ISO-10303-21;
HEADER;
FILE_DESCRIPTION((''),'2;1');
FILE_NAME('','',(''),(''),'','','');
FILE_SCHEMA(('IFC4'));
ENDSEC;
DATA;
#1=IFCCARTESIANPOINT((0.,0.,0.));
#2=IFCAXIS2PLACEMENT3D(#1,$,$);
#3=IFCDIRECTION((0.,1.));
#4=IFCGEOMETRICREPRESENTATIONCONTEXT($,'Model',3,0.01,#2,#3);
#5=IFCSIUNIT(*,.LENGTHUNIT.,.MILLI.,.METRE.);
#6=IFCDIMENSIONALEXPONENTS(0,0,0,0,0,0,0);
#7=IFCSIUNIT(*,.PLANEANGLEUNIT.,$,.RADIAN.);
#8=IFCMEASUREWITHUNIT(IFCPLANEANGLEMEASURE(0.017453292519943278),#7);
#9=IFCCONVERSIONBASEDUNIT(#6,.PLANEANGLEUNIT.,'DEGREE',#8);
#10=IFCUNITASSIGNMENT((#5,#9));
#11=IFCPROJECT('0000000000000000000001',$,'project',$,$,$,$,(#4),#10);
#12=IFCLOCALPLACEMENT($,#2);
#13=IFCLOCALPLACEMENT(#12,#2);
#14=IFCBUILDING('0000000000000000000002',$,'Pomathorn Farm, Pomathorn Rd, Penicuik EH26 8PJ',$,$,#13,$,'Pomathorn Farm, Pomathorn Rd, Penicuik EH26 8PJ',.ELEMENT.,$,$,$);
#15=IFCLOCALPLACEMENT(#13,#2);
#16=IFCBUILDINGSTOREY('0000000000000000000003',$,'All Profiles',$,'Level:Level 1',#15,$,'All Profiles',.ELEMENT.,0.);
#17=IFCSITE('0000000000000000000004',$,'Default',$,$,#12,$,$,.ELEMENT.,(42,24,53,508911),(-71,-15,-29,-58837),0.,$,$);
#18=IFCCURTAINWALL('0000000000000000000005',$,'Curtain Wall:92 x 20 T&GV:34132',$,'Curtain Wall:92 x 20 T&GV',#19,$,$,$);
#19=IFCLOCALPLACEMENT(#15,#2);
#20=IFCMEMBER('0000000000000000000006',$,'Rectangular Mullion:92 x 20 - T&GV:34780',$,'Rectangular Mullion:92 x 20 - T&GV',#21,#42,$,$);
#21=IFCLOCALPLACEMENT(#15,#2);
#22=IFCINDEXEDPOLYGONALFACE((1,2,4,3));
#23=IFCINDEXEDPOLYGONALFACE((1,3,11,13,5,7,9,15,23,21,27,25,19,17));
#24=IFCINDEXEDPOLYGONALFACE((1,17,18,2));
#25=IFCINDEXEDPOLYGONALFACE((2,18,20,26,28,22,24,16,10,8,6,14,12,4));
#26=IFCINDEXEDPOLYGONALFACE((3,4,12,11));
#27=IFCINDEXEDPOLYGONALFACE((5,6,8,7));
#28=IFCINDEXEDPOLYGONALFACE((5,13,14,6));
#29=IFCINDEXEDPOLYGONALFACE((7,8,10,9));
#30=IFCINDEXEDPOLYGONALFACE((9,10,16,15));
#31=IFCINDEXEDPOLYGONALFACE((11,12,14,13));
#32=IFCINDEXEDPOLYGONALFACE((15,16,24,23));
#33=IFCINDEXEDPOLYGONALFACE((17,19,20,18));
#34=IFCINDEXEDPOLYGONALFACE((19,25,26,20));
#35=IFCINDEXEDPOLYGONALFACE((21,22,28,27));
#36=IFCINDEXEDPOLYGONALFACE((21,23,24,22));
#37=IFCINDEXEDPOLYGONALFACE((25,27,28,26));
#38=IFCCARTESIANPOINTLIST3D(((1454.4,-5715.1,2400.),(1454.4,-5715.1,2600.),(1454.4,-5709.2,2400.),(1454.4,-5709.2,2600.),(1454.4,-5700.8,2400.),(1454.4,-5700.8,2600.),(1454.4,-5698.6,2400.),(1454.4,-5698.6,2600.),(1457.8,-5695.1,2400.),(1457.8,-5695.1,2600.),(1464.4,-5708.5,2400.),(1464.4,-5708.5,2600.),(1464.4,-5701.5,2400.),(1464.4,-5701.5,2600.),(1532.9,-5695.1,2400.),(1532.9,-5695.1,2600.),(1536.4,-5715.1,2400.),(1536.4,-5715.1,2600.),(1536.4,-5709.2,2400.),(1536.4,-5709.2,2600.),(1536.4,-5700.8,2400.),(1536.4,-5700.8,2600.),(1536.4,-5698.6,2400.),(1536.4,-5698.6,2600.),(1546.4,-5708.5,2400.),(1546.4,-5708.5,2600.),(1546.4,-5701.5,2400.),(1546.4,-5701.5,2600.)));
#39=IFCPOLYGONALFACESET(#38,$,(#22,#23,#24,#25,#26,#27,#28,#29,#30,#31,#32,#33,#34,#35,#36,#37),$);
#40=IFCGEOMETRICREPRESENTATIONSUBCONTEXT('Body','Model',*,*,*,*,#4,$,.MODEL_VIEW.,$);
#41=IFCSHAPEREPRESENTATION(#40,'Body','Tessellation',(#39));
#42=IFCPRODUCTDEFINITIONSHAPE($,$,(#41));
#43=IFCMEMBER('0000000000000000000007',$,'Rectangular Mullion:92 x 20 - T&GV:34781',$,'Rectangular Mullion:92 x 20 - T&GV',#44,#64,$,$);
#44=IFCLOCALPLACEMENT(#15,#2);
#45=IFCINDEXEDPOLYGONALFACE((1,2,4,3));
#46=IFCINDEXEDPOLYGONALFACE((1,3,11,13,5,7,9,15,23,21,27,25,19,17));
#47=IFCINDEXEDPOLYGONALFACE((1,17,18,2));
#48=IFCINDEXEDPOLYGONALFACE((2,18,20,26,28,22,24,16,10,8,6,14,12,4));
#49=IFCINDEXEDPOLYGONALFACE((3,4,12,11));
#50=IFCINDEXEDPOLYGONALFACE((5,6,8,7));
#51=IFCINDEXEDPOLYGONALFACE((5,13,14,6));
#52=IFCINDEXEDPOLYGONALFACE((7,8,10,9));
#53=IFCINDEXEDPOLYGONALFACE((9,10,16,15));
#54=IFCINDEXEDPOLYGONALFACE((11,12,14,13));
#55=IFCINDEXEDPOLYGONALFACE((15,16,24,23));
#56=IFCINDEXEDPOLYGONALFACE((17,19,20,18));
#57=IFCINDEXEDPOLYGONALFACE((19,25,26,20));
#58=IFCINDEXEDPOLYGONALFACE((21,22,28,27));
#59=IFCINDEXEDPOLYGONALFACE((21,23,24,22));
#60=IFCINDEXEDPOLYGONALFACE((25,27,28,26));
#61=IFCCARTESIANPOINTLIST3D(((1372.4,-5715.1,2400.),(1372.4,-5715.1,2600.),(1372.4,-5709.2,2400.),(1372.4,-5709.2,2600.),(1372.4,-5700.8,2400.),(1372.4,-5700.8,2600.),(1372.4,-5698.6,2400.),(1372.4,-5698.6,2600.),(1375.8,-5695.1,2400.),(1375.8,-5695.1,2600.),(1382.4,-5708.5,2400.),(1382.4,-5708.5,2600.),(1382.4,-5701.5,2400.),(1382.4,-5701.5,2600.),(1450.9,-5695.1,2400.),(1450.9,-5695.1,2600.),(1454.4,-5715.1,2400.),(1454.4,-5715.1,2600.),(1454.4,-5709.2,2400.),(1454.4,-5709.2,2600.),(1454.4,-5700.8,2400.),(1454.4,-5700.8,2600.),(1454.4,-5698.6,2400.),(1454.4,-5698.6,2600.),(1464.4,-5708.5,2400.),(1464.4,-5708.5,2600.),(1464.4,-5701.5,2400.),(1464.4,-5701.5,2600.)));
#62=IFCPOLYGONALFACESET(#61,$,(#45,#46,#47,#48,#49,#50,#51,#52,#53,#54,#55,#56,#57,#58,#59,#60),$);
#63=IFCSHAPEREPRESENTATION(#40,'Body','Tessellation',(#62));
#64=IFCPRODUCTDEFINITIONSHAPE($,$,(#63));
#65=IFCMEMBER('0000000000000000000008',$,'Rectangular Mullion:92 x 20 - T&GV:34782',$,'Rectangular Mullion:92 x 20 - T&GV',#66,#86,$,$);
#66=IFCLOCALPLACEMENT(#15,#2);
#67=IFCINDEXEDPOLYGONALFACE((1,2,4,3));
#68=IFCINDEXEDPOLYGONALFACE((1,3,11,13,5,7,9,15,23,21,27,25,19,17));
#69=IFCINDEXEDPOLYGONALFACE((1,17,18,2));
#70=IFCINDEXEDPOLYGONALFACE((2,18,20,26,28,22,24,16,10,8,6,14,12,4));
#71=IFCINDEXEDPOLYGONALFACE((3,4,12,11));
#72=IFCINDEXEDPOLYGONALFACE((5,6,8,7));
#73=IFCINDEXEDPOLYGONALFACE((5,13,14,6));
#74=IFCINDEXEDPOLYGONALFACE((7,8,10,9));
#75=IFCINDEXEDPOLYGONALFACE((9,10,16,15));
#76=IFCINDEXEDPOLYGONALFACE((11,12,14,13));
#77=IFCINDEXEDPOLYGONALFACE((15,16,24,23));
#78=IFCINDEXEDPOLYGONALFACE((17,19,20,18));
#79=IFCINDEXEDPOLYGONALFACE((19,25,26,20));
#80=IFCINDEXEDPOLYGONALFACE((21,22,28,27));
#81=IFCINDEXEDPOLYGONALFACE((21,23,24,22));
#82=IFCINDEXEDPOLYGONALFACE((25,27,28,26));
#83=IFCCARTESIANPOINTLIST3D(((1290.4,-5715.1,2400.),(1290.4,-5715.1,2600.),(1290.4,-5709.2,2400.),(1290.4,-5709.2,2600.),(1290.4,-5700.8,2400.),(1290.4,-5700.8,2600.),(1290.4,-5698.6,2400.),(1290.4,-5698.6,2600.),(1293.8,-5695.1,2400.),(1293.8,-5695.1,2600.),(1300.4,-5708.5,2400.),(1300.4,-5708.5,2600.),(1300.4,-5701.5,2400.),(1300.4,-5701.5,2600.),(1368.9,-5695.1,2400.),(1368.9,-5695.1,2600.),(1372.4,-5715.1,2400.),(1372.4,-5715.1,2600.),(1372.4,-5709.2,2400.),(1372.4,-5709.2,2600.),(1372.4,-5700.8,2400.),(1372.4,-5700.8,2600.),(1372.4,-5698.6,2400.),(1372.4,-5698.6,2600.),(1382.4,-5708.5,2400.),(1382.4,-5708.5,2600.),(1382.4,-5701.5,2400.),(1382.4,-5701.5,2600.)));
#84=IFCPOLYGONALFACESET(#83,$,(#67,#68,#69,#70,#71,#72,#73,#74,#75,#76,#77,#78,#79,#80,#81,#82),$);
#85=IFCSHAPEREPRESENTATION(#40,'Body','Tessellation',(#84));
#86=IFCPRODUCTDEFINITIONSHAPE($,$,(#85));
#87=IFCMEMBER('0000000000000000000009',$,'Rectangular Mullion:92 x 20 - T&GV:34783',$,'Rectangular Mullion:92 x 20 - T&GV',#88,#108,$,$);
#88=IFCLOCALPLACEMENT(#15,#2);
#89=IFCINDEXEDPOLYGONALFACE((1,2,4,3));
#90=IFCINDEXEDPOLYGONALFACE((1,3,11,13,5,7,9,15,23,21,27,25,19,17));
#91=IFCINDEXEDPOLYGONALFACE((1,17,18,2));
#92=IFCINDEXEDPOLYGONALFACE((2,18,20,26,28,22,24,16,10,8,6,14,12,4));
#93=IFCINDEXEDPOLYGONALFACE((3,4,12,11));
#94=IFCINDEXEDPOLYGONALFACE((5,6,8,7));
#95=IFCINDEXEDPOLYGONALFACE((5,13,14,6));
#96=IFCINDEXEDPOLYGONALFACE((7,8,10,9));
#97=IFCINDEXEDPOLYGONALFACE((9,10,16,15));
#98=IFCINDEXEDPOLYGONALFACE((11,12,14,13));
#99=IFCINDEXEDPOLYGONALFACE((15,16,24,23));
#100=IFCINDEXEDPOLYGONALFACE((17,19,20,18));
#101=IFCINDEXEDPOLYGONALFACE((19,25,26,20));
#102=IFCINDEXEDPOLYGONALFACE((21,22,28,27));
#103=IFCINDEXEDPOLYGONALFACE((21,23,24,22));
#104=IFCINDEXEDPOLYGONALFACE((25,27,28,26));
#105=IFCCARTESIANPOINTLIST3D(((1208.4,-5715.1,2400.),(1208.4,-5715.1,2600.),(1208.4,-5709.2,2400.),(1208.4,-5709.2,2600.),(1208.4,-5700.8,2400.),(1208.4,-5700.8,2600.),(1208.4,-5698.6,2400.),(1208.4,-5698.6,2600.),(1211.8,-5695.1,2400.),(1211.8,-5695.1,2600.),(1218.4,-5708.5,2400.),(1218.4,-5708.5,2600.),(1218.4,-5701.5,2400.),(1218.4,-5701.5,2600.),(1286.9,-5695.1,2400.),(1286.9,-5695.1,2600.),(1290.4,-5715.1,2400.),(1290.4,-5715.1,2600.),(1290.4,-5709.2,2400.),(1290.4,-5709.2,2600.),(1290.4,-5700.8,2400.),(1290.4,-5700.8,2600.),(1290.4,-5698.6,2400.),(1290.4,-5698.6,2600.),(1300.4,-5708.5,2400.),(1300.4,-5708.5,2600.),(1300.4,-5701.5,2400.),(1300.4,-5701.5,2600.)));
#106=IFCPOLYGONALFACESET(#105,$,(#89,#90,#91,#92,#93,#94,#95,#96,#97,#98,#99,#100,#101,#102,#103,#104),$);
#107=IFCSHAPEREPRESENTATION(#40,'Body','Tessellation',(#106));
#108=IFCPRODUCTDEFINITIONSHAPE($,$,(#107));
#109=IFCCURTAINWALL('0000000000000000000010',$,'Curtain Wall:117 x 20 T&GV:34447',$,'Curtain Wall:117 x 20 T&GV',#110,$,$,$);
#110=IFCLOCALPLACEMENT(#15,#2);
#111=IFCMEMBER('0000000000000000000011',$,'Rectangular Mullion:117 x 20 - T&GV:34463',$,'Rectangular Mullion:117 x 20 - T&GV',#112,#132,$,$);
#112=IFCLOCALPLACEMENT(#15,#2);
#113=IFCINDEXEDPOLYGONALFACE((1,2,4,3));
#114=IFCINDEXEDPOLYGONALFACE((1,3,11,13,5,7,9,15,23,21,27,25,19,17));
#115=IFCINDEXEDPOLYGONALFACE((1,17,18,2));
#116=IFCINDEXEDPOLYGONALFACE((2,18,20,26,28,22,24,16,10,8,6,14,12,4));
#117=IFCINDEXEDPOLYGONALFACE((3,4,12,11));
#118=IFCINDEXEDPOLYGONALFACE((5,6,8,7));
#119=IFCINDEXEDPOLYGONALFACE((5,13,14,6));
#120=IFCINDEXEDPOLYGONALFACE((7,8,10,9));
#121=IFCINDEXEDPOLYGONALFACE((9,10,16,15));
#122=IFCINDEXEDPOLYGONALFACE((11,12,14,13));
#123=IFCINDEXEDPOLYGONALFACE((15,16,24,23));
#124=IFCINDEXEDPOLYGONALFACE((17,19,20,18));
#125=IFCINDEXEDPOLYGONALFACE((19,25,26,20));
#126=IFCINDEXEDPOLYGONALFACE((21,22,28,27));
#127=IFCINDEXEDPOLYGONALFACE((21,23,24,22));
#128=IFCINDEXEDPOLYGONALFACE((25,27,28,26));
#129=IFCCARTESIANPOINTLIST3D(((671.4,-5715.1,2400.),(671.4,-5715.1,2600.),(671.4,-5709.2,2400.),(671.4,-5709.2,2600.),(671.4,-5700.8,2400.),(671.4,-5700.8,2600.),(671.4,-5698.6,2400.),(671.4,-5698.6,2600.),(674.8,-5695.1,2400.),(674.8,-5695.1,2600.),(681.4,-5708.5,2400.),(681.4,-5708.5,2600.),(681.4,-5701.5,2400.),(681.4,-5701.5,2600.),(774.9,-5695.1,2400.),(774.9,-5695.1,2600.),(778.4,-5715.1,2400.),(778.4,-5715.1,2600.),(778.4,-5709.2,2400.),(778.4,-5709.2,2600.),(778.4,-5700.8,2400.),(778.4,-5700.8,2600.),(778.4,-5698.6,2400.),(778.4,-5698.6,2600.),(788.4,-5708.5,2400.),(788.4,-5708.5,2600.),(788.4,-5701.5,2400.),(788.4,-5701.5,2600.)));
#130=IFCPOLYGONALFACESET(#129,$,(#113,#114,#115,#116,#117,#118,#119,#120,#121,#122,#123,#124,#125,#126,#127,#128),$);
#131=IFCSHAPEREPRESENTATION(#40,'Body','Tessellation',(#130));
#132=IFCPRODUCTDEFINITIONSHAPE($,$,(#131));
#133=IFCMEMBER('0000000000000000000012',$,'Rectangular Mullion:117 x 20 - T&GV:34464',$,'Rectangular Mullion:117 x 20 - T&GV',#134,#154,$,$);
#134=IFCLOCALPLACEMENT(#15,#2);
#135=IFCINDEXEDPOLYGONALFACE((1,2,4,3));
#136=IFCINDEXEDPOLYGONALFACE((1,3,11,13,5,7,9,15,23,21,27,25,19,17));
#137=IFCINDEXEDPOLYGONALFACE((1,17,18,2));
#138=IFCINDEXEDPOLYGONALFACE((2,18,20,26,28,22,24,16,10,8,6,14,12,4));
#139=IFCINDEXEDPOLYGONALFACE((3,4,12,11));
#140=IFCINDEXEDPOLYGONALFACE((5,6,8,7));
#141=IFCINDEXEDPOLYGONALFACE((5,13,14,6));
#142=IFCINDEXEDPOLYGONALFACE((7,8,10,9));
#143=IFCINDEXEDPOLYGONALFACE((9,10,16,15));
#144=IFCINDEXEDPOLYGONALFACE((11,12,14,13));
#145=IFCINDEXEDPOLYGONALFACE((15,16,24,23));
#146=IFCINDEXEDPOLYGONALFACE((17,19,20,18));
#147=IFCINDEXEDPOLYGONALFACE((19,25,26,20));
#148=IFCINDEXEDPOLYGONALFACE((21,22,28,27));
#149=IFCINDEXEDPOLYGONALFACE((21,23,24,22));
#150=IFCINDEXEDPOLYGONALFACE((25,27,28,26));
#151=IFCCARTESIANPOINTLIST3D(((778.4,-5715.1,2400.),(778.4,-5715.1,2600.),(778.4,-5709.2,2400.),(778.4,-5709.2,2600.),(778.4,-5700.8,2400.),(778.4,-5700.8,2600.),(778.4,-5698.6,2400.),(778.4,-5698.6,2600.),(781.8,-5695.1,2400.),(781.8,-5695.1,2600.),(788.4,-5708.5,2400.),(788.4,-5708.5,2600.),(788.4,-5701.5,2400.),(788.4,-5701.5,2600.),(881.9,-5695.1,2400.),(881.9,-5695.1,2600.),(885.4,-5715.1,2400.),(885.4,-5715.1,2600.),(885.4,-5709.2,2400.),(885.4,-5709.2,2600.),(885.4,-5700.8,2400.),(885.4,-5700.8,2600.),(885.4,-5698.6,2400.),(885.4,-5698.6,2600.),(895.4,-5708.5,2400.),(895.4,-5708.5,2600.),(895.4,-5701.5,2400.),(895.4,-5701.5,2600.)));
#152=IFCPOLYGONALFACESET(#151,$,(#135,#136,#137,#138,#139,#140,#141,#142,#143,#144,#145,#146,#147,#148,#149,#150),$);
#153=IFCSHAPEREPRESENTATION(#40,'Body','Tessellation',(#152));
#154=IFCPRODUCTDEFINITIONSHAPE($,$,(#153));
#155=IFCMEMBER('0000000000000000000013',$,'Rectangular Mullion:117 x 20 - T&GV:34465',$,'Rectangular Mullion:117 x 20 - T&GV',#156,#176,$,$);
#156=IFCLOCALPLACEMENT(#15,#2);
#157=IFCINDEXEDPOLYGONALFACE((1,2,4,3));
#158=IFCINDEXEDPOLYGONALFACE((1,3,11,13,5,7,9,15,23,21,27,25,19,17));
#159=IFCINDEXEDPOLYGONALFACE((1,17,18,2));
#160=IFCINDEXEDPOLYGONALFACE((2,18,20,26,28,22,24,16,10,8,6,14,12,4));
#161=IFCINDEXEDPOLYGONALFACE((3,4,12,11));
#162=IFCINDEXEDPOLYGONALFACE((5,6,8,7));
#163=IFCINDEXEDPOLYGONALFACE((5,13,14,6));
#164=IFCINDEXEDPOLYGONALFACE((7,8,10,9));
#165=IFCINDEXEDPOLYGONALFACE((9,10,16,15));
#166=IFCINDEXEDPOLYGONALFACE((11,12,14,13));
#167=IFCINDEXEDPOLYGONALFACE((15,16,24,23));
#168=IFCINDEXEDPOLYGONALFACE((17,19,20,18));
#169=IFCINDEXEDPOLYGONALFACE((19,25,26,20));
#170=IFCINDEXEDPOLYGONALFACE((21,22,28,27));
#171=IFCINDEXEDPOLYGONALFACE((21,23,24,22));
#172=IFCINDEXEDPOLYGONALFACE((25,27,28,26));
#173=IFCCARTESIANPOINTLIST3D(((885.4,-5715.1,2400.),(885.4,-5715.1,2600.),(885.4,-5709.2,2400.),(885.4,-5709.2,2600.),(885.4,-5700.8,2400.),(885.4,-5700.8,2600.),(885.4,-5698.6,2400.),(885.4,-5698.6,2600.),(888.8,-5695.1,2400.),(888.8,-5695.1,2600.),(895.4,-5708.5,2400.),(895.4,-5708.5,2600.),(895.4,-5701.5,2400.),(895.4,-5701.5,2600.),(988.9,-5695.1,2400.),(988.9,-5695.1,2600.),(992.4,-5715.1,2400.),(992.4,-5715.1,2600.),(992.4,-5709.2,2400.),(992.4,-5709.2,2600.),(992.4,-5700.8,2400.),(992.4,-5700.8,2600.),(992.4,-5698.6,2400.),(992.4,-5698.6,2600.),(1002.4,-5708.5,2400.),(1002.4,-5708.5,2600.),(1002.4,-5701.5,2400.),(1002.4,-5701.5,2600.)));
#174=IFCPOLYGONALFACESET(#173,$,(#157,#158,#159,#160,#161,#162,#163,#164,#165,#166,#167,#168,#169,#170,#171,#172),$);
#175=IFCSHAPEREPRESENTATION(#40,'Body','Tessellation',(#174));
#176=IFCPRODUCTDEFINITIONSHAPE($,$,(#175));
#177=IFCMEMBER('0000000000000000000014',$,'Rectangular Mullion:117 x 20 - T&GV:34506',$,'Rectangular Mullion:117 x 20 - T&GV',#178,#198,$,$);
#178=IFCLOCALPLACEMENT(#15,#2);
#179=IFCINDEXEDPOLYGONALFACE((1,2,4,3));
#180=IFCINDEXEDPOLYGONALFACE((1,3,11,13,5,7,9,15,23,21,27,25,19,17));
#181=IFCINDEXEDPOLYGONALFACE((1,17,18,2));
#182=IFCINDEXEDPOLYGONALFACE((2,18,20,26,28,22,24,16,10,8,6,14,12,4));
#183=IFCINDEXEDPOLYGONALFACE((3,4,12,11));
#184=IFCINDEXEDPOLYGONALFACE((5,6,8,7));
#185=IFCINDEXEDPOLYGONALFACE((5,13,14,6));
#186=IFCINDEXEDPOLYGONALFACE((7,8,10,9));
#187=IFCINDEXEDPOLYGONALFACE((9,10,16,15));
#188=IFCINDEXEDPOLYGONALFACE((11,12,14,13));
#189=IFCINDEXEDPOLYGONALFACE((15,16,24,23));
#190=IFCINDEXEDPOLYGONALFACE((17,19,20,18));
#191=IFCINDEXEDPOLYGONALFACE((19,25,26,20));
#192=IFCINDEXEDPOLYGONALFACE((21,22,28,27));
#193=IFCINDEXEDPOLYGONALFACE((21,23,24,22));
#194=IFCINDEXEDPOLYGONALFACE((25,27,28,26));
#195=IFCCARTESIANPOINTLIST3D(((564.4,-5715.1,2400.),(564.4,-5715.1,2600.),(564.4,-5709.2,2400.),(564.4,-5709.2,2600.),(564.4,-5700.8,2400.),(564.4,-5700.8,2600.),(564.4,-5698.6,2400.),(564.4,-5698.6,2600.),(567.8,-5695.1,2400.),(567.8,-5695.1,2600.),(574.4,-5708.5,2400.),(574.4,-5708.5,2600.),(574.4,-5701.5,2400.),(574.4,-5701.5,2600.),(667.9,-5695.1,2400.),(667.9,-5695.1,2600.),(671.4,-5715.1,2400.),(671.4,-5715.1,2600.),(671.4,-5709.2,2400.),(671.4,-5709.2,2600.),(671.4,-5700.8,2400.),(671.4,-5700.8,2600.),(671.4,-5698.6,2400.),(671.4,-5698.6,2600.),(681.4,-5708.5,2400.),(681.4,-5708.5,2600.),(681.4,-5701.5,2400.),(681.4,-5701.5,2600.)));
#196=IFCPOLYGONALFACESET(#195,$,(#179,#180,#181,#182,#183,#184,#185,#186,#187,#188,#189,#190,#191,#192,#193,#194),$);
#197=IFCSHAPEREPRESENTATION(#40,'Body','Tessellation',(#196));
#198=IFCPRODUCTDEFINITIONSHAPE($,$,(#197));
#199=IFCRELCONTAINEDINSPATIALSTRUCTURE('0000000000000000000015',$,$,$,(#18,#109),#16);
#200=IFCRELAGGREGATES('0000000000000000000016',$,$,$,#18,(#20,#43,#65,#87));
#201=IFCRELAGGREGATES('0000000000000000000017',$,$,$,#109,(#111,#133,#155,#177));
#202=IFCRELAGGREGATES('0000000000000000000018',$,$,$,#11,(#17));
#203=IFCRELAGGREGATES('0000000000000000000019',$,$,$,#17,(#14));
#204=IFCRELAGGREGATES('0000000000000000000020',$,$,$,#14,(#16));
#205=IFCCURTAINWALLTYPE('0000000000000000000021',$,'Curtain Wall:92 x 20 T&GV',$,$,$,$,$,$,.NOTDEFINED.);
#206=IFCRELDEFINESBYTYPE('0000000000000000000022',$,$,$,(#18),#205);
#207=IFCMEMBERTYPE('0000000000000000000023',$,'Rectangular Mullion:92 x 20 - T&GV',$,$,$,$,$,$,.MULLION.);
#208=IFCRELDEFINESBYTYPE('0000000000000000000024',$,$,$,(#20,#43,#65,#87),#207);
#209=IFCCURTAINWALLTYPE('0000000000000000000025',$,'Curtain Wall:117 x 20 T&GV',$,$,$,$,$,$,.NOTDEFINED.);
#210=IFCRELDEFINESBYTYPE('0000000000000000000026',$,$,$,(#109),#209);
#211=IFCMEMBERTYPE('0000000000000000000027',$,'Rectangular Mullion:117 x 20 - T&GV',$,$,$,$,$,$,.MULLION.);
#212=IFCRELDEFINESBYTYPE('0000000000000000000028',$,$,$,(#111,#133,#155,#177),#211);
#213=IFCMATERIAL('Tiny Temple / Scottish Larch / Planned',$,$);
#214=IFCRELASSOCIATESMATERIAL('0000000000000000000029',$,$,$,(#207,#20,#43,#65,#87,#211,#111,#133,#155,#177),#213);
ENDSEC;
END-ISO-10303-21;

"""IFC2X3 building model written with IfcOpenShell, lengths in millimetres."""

from ifc_helpers import new_model, entity, si_unit, converted_unit, direction, frame, origin, place, context, subcontext, project, spatial, polyline, outline, extrude, source, transform, mapped, material, type_object, type_shapes, element, aggregate, save


model = new_model("IFC2X3")

# Units and contexts
model_context = context("Model", 3, precision=0.01, world=origin(), true_north=direction((0.0, 1.0)))
body_context = subcontext(model_context, "Body", "Model", "MODEL_VIEW")
ifc_project = project(units=[si_unit("LENGTHUNIT", "METRE", prefix="MILLI"), converted_unit("PLANEANGLEUNIT", "DEGREE", entity("IfcPlaneAngleMeasure", 0.017453292519943278), si_unit("PLANEANGLEUNIT", "RADIAN"), dimensions=[0, 0, 0, 0, 0, 0, 0])], contexts=[model_context])

# Site, building, storey
site_placement = place(None, origin())
site = spatial("IfcSite", under=ifc_project, at=site_placement, Name="Default", CompositionType="ELEMENT", RefLatitude=(42, 24, 53, 508911), RefLongitude=(-71, -15, -29, -58837), RefElevation=0.0)
building_placement = place(site_placement, origin())
building = spatial("IfcBuilding", under=site, at=building_placement, Name="Pomathorn Farm, Pomathorn Rd, Penicuik EH26 8PJ", LongName="Pomathorn Farm, Pomathorn Rd, Penicuik EH26 8PJ", CompositionType="ELEMENT")
storey_placement = place(building_placement, origin())
storey = spatial("IfcBuildingStorey", under=building, at=storey_placement, Name="All Profiles", ObjectType="Level:Level 1", LongName="All Profiles", CompositionType="ELEMENT", Elevation=0.0)

# Shared definitions
ifc_material = material(Name="Tiny Temple / Scottish Larch / Planned")

# Curtain walls, members
curtain_wall_type_1 = type_object("IfcCurtainWallType", Name="Curtain Wall:92 x 20 T&GV", PredefinedType="NOTDEFINED")
curtain_wall_1_placement = place(storey_placement, origin())
curtain_wall_1 = element("IfcCurtainWall", 1, at=curtain_wall_1_placement, inside=storey, type_object=curtain_wall_type_1, Name="Curtain Wall:92 x 20 T&GV:34132", ObjectType="Curtain Wall:92 x 20 T&GV")
member_type_1 = type_object("IfcMemberType", Name="Rectangular Mullion:92 x 20 - T&GV", PredefinedType="MULLION", material=ifc_material)
shared_shape_1 = source(origin(), body_context, "Body", "SweptSolid", [
    extrude(outline(polyline([(-38.1, -11.0), (43.9, -11.0), (43.9, -5.1), (33.9, -4.4), (33.9, 2.6), (43.9, 3.3), (43.9, 5.5), (40.4, 9.0), (-34.7, 9.0), (-38.1, 5.5), (-38.1, 3.3), (-48.1, 2.6), (-48.1, -4.4), (-38.1, -5.1), (-38.1, -11.0)])), frame((-48.1, -11.0, -200.0), z_axis=(0.0, 0.0, 1.0), x_axis=(-1.0, 0.0, 0.0)), (0.0, 0.0, 1.0), 200.0),
])
type_shapes(member_type_1, [shared_shape_1])
member_1_placement = place(curtain_wall_1_placement, frame((1546.4, -5715.1, 2400.0), z_axis=(0.0, 0.0, -1.0), x_axis=(1.0, 0.0, 0.0)))
member_1 = element("IfcMember", 2, at=member_1_placement, type_object=member_type_1, material=ifc_material, Name="Rectangular Mullion:92 x 20 - T&GV:34780", ObjectType="Rectangular Mullion:92 x 20 - T&GV", context=body_context, shape_type="MappedRepresentation", body=[
    mapped(shared_shape_1, transform((0.0, 0.0, 0.0), scale=1.0)),
])
member_2_placement = place(curtain_wall_1_placement, frame((1464.4, -5715.1, 2400.0), z_axis=(0.0, 0.0, -1.0), x_axis=(1.0, 0.0, 0.0)))
member_2 = element("IfcMember", 3, at=member_2_placement, type_object=member_type_1, material=ifc_material, Name="Rectangular Mullion:92 x 20 - T&GV:34781", ObjectType="Rectangular Mullion:92 x 20 - T&GV", context=body_context, shape_type="MappedRepresentation", body=[
    mapped(shared_shape_1, transform((0.0, 0.0, 0.0), scale=1.0)),
])
member_3_placement = place(curtain_wall_1_placement, frame((1382.4, -5715.1, 2400.0), z_axis=(0.0, 0.0, -1.0), x_axis=(1.0, 0.0, 0.0)))
member_3 = element("IfcMember", 4, at=member_3_placement, type_object=member_type_1, material=ifc_material, Name="Rectangular Mullion:92 x 20 - T&GV:34782", ObjectType="Rectangular Mullion:92 x 20 - T&GV", context=body_context, shape_type="MappedRepresentation", body=[
    mapped(shared_shape_1, transform((0.0, 0.0, 0.0), scale=1.0)),
])
member_4_placement = place(curtain_wall_1_placement, frame((1300.4, -5715.1, 2400.0), z_axis=(0.0, 0.0, -1.0), x_axis=(1.0, 0.0, 0.0)))
member_4 = element("IfcMember", 5, at=member_4_placement, type_object=member_type_1, material=ifc_material, Name="Rectangular Mullion:92 x 20 - T&GV:34783", ObjectType="Rectangular Mullion:92 x 20 - T&GV", context=body_context, shape_type="MappedRepresentation", body=[
    mapped(shared_shape_1, transform((0.0, 0.0, 0.0), scale=1.0)),
])
aggregate(curtain_wall_1, [member_1, member_2, member_3, member_4])
curtain_wall_type_2 = type_object("IfcCurtainWallType", Name="Curtain Wall:117 x 20 T&GV", PredefinedType="NOTDEFINED")
curtain_wall_2_placement = place(storey_placement, origin())
curtain_wall_2 = element("IfcCurtainWall", 6, at=curtain_wall_2_placement, inside=storey, type_object=curtain_wall_type_2, Name="Curtain Wall:117 x 20 T&GV:34447", ObjectType="Curtain Wall:117 x 20 T&GV")
member_type_2 = type_object("IfcMemberType", Name="Rectangular Mullion:117 x 20 - T&GV", PredefinedType="MULLION", material=ifc_material)
shared_shape_2 = source(origin(), body_context, "Body", "SweptSolid", [
    extrude(outline(polyline([(-50.6, -11.0), (56.4, -11.0), (56.4, -5.1), (46.4, -4.4), (46.4, 2.6), (56.4, 3.3), (56.4, 5.5), (52.9, 9.0), (-47.2, 9.0), (-50.6, 5.5), (-50.6, 3.3), (-60.6, 2.6), (-60.6, -4.4), (-50.6, -5.1), (-50.6, -11.0)])), frame((-60.6, -11.0, -200.0), z_axis=(0.0, 0.0, 1.0), x_axis=(-1.0, 0.0, 0.0)), (0.0, 0.0, 1.0), 200.0),
])
type_shapes(member_type_2, [shared_shape_2])
member_5_placement = place(curtain_wall_2_placement, frame((788.4, -5715.1, 2400.0), z_axis=(0.0, 0.0, -1.0), x_axis=(1.0, 0.0, 0.0)))
member_5 = element("IfcMember", 7, at=member_5_placement, type_object=member_type_2, material=ifc_material, Name="Rectangular Mullion:117 x 20 - T&GV:34463", ObjectType="Rectangular Mullion:117 x 20 - T&GV", context=body_context, shape_type="MappedRepresentation", body=[
    mapped(shared_shape_2, transform((0.0, 0.0, 0.0), scale=1.0)),
])
member_6_placement = place(curtain_wall_2_placement, frame((895.4, -5715.1, 2400.0), z_axis=(0.0, 0.0, -1.0), x_axis=(1.0, 0.0, 0.0)))
member_6 = element("IfcMember", 8, at=member_6_placement, type_object=member_type_2, material=ifc_material, Name="Rectangular Mullion:117 x 20 - T&GV:34464", ObjectType="Rectangular Mullion:117 x 20 - T&GV", context=body_context, shape_type="MappedRepresentation", body=[
    mapped(shared_shape_2, transform((0.0, 0.0, 0.0), scale=1.0)),
])
member_7_placement = place(curtain_wall_2_placement, frame((1002.4, -5715.1, 2400.0), z_axis=(0.0, 0.0, -1.0), x_axis=(1.0, 0.0, 0.0)))
member_7 = element("IfcMember", 9, at=member_7_placement, type_object=member_type_2, material=ifc_material, Name="Rectangular Mullion:117 x 20 - T&GV:34465", ObjectType="Rectangular Mullion:117 x 20 - T&GV", context=body_context, shape_type="MappedRepresentation", body=[
    mapped(shared_shape_2, transform((0.0, 0.0, 0.0), scale=1.0)),
])
member_8_placement = place(curtain_wall_2_placement, frame((681.4, -5715.1, 2400.0), z_axis=(0.0, 0.0, -1.0), x_axis=(1.0, 0.0, 0.0)))
member_8 = element("IfcMember", 10, at=member_8_placement, type_object=member_type_2, material=ifc_material, Name="Rectangular Mullion:117 x 20 - T&GV:34506", ObjectType="Rectangular Mullion:117 x 20 - T&GV", context=body_context, shape_type="MappedRepresentation", body=[
    mapped(shared_shape_2, transform((0.0, 0.0, 0.0), scale=1.0)),
])
aggregate(curtain_wall_2, [member_5, member_6, member_7, member_8])

save(model, "model.ifc")
